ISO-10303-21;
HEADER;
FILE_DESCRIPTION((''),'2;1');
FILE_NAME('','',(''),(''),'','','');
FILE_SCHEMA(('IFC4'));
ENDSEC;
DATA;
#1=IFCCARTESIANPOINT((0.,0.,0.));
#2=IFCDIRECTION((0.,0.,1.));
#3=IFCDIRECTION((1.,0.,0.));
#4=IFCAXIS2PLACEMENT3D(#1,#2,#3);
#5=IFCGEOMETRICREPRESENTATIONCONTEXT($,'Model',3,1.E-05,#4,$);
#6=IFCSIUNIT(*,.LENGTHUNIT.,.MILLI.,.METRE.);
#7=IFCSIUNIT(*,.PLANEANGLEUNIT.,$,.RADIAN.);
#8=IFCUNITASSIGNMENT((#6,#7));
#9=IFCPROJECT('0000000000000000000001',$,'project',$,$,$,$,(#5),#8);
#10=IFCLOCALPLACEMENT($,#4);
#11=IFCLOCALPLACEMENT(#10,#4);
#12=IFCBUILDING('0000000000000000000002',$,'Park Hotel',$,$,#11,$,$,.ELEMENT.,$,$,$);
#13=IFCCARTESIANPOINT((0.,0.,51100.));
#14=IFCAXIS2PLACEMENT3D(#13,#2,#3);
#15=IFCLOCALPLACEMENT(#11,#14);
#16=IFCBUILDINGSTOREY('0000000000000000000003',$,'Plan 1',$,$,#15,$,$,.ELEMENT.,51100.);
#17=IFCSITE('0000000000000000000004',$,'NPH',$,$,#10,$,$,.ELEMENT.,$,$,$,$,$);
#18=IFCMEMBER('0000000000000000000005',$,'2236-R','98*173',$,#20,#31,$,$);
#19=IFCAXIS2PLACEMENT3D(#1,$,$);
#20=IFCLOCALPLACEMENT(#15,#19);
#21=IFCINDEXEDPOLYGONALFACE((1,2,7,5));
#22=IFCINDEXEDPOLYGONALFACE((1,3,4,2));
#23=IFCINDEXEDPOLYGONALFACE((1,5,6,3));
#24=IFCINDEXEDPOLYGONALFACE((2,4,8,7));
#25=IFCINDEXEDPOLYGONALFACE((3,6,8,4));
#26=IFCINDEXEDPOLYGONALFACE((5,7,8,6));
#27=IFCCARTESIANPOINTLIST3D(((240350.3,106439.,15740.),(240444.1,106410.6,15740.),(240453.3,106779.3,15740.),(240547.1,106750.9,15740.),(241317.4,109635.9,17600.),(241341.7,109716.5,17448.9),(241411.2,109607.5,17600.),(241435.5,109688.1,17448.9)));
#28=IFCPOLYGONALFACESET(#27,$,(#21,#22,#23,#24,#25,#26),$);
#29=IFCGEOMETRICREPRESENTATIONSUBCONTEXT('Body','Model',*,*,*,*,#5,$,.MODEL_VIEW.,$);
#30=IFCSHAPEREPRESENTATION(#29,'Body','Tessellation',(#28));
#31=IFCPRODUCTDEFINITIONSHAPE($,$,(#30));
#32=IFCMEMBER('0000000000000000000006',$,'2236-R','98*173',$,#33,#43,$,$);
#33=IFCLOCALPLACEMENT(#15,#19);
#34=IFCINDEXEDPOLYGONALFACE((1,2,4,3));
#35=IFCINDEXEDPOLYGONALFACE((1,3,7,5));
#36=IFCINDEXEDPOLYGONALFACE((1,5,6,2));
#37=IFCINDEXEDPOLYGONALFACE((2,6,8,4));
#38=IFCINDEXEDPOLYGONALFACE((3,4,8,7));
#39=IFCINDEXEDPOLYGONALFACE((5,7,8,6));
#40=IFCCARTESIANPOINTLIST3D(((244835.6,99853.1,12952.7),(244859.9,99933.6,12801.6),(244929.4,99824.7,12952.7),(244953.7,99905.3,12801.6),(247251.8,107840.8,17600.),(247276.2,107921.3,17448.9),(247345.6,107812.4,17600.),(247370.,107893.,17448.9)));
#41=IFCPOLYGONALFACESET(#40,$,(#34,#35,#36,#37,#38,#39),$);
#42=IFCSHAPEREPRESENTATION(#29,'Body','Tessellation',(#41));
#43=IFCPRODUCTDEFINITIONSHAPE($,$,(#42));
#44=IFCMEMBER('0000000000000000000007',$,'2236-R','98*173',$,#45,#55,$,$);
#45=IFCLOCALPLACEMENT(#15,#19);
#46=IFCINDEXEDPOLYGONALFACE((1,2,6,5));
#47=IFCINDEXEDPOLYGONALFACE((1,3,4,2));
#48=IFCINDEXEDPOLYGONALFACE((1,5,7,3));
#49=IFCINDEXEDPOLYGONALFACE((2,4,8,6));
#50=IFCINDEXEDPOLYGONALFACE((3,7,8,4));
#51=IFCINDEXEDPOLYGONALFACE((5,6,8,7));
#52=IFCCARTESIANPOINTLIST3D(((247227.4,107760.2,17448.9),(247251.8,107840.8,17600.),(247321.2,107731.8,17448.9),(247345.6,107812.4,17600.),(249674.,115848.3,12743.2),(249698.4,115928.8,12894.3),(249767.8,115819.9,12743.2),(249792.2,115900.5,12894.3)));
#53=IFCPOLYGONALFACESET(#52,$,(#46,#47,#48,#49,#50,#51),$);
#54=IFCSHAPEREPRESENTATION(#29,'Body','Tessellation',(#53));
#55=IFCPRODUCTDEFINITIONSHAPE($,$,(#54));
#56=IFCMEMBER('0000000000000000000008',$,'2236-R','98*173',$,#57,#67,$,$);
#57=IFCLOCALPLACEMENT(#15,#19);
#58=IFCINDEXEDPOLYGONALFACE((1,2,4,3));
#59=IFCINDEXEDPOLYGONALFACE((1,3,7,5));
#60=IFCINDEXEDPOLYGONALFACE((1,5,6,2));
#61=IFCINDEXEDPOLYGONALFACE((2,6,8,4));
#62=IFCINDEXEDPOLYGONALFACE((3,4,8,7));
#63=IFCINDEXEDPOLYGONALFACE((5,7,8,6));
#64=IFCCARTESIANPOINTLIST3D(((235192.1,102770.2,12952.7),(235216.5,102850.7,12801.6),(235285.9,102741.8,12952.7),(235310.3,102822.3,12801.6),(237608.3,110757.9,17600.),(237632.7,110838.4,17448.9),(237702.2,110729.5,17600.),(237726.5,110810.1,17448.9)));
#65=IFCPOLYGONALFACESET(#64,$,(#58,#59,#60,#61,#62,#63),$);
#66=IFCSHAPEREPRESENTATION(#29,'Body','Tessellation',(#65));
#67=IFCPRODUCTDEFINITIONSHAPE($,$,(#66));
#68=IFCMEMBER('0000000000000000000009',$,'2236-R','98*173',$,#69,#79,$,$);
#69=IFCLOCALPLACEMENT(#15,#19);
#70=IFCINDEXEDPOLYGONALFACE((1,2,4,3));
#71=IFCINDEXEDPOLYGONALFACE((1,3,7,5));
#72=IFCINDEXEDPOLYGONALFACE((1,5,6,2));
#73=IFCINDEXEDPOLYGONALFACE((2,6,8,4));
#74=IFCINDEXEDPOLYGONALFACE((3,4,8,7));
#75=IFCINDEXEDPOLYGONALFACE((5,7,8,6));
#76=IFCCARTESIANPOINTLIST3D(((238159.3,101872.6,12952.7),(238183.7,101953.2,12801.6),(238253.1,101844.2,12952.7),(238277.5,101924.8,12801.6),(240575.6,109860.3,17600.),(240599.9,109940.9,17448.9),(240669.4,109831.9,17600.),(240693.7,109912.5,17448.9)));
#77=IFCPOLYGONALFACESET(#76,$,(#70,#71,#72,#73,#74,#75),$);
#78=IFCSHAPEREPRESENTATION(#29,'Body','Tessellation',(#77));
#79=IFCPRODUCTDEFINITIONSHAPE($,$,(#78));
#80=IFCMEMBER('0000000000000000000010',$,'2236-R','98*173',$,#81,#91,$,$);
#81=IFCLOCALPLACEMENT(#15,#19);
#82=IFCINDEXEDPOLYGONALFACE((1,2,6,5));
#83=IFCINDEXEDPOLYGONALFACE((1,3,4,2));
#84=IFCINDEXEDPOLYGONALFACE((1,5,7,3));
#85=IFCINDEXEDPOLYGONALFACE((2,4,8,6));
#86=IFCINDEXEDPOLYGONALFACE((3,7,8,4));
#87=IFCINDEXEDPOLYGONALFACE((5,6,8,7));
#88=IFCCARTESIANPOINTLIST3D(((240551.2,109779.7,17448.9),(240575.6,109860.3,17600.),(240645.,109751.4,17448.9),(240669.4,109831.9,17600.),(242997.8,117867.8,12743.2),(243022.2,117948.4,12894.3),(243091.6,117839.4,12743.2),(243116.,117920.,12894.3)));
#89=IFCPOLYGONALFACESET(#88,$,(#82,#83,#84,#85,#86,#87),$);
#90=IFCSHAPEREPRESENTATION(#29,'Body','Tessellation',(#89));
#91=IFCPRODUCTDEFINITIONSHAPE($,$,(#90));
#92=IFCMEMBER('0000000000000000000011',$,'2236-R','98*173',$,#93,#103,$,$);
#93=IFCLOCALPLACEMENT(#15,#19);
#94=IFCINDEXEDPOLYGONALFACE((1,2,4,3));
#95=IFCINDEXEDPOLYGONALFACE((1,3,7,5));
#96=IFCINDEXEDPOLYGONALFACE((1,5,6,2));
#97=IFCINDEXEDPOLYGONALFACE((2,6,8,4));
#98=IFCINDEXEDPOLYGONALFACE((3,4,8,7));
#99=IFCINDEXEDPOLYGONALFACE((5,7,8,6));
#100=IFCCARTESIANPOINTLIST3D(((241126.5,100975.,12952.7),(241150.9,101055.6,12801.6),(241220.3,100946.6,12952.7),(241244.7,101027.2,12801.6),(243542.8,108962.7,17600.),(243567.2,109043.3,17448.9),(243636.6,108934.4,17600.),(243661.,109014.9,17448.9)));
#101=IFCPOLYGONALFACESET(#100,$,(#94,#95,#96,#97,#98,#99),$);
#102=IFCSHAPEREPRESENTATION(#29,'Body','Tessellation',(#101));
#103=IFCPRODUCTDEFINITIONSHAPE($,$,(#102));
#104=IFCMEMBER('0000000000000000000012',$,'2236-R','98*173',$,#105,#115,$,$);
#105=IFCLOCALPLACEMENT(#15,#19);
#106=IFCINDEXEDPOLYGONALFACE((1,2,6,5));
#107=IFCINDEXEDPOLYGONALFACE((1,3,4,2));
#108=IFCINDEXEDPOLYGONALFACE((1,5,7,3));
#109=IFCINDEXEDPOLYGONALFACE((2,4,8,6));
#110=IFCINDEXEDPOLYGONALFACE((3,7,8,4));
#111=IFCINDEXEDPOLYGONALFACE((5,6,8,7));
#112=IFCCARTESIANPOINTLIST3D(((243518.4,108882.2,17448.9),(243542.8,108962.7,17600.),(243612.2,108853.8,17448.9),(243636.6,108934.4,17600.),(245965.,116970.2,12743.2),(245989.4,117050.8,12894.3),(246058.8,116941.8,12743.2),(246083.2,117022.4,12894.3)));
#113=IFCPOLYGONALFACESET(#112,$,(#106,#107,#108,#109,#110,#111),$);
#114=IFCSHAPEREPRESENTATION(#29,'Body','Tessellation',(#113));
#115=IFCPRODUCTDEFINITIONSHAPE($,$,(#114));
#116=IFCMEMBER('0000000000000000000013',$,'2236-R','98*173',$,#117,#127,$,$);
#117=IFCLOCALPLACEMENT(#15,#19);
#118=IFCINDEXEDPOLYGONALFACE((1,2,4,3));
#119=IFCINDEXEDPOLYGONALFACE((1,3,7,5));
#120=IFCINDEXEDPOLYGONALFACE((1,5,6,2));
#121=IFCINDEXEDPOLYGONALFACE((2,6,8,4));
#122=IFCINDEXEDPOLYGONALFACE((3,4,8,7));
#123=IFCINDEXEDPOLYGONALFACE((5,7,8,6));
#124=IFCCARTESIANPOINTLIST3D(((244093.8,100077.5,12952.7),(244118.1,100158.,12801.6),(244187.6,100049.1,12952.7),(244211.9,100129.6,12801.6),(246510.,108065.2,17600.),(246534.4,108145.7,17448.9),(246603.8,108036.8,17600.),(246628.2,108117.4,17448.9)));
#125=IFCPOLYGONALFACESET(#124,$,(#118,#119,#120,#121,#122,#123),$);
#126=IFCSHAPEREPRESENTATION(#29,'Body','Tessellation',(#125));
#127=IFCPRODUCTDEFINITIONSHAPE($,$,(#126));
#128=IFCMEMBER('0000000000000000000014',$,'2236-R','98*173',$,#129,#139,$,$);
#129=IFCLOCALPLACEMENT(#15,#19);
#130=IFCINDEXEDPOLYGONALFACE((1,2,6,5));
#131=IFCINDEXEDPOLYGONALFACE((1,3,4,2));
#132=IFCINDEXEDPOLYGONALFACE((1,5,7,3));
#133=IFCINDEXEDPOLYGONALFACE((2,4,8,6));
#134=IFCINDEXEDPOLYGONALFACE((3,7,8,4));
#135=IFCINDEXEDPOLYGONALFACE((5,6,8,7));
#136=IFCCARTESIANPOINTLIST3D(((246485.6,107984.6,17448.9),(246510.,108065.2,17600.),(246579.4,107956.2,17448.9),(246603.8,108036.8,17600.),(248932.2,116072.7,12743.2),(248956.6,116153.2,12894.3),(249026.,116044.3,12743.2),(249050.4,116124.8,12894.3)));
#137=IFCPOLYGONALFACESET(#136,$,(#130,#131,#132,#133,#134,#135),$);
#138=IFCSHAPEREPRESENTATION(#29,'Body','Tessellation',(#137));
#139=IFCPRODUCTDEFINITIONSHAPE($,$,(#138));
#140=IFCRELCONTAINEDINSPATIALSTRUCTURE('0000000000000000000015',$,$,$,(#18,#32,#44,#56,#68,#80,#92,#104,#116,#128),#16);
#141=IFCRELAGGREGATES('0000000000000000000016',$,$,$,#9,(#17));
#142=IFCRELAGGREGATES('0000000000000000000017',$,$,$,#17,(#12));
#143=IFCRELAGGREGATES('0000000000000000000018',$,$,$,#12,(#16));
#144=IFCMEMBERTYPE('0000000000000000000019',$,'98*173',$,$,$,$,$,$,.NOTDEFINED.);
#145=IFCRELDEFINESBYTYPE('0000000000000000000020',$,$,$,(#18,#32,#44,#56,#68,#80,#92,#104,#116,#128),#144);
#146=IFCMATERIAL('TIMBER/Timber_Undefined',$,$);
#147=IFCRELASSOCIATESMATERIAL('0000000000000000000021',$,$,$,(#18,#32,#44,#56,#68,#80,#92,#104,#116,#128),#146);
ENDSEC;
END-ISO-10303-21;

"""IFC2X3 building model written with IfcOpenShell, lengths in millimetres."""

from ifc_helpers import new_model, si_unit, frame, origin_with_axes, origin_2d_with_axis, place, context, subcontext, project, spatial, rectangle, extrude, clip, halfspace, material, type_object, element, save


model = new_model("IFC2X3")

# Units and contexts
model_context = context("Model", 3, precision=1e-05, world=origin_with_axes())
body_context = subcontext(model_context, "Body", "Model", "MODEL_VIEW")
ifc_project = project(units=[si_unit("LENGTHUNIT", "METRE", prefix="MILLI"), si_unit("PLANEANGLEUNIT", "RADIAN")], contexts=[model_context])

# Site, building, storey
site_placement = place(None, origin_with_axes())
site = spatial("IfcSite", under=ifc_project, at=site_placement, Name="NPH", CompositionType="ELEMENT")
building_placement = place(site_placement, origin_with_axes())
building = spatial("IfcBuilding", under=site, at=building_placement, Name="Park Hotel", CompositionType="ELEMENT")
storey_placement = place(building_placement, frame((0.0, 0.0, 51100.0), z_axis=(0.0, 0.0, 1.0), x_axis=(1.0, 0.0, 0.0)))
storey = spatial("IfcBuildingStorey", under=building, at=storey_placement, Name="Plan 1", CompositionType="ELEMENT", Elevation=51100.0)

# Members
ifc_material = material(Name="TIMBER/Timber_Undefined")
member_type = type_object("IfcMemberType", Name="98*173", PredefinedType="NOTDEFINED")
member_1_placement = place(storey_placement, frame((241376.5, 109662.0, 17524.4), z_axis=(-0.957167, 0.289538, 0.0), x_axis=(-0.252959, -0.836241, -0.486531)))
element("IfcMember", 1, at=member_1_placement, inside=storey, type_object=member_type, material=ifc_material, Name="2236-R", Description="98*173", context=body_context, shape_type="Clipping", body=[
    clip(extrude(rectangle(XDim=173.0, YDim=98.0, at=origin_2d_with_axis()), frame((9551.9, 0.0, 0.0), z_axis=(-1.0, 0.0, 0.0), x_axis=(0.0, -1.0, 0.0)), (0.0, 0.0, 1.0), 9551.9), halfspace(frame((4639.3, 541.1, -40.5), z_axis=(0.486531, -0.873663, 0.0), x_axis=(0.0, 0.0, -1.0)), False)),
])
member_2_placement = place(storey_placement, frame((247310.9, 107866.9, 17524.4), z_axis=(-0.957167, 0.289538, 0.0), x_axis=(-0.252959, -0.836241, -0.486531)))
element("IfcMember", 2, at=member_2_placement, inside=storey, type_object=member_type, material=ifc_material, Name="2236-R", Description="98*173", context=body_context, shape_type="SweptSolid", body=[
    extrude(rectangle(XDim=173.0, YDim=98.0, at=origin_2d_with_axis()), frame((9551.9, 0.0, 0.0), z_axis=(-1.0, 0.0, 0.0), x_axis=(0.0, -1.0, 0.0)), (0.0, 0.0, 1.0), 9551.9),
])
member_3_placement = place(storey_placement, frame((247286.5, 107786.3, 17524.4), z_axis=(-0.957167, 0.289538, 0.0), x_axis=(0.252959, 0.836242, -0.48653)))
element("IfcMember", 3, at=member_3_placement, inside=storey, type_object=member_type, material=ifc_material, Name="2236-R", Description="98*173", context=body_context, shape_type="SweptSolid", body=[
    extrude(rectangle(XDim=173.0, YDim=98.0, at=origin_2d_with_axis()), frame((9671.9, 0.0, 0.0), z_axis=(-1.0, 0.0, 0.0), x_axis=(0.0, -1.0, 0.0)), (0.0, 0.0, 1.0), 9671.9),
])
for number, where, z_axis, x_axis, name in (
    (4, (237667.4, 110784.0, 17524.4), (-0.957167, 0.289538, 0.0), (-0.252959, -0.836241, -0.486531), "2236-R"),
    (5, (240634.7, 109886.4, 17524.4), (-0.957167, 0.289538, 0.0), (-0.252959, -0.836241, -0.486531), "2236-R"),
):
    element("IfcMember", number, at=place(storey_placement, frame(where, z_axis=z_axis, x_axis=x_axis)), inside=storey, type_object=member_type, material=ifc_material, Name=name, Description="98*173", context=body_context, shape_type="SweptSolid", body=[
        extrude(rectangle(XDim=173.0, YDim=98.0, at=origin_2d_with_axis()), frame((9551.9, 0.0, 0.0), z_axis=(-1.0, 0.0, 0.0), x_axis=(0.0, -1.0, 0.0)), (0.0, 0.0, 1.0), 9551.9),
    ])
member_4_placement = place(storey_placement, frame((240610.3, 109805.8, 17524.4), z_axis=(-0.957167, 0.289538, 0.0), x_axis=(0.252959, 0.836242, -0.48653)))
element("IfcMember", 6, at=member_4_placement, inside=storey, type_object=member_type, material=ifc_material, Name="2236-R", Description="98*173", context=body_context, shape_type="SweptSolid", body=[
    extrude(rectangle(XDim=173.0, YDim=98.0, at=origin_2d_with_axis()), frame((9671.9, 0.0, 0.0), z_axis=(-1.0, 0.0, 0.0), x_axis=(0.0, -1.0, 0.0)), (0.0, 0.0, 1.0), 9671.9),
])
member_5_placement = place(storey_placement, frame((243601.9, 108988.8, 17524.4), z_axis=(-0.957167, 0.289538, 0.0), x_axis=(-0.252959, -0.836241, -0.486531)))
element("IfcMember", 7, at=member_5_placement, inside=storey, type_object=member_type, material=ifc_material, Name="2236-R", Description="98*173", context=body_context, shape_type="SweptSolid", body=[
    extrude(rectangle(XDim=173.0, YDim=98.0, at=origin_2d_with_axis()), frame((9551.9, 0.0, 0.0), z_axis=(-1.0, 0.0, 0.0), x_axis=(0.0, -1.0, 0.0)), (0.0, 0.0, 1.0), 9551.9),
])
member_6_placement = place(storey_placement, frame((243577.5, 108908.3, 17524.4), z_axis=(-0.957167, 0.289538, 0.0), x_axis=(0.252959, 0.836242, -0.48653)))
element("IfcMember", 8, at=member_6_placement, inside=storey, type_object=member_type, material=ifc_material, Name="2236-R", Description="98*173", context=body_context, shape_type="SweptSolid", body=[
    extrude(rectangle(XDim=173.0, YDim=98.0, at=origin_2d_with_axis()), frame((9671.9, 0.0, 0.0), z_axis=(-1.0, 0.0, 0.0), x_axis=(0.0, -1.0, 0.0)), (0.0, 0.0, 1.0), 9671.9),
])
member_7_placement = place(storey_placement, frame((246569.1, 108091.3, 17524.4), z_axis=(-0.957167, 0.289538, 0.0), x_axis=(-0.252959, -0.836241, -0.486531)))
element("IfcMember", 9, at=member_7_placement, inside=storey, type_object=member_type, material=ifc_material, Name="2236-R", Description="98*173", context=body_context, shape_type="SweptSolid", body=[
    extrude(rectangle(XDim=173.0, YDim=98.0, at=origin_2d_with_axis()), frame((9551.9, 0.0, 0.0), z_axis=(-1.0, 0.0, 0.0), x_axis=(0.0, -1.0, 0.0)), (0.0, 0.0, 1.0), 9551.9),
])
member_8_placement = place(storey_placement, frame((246544.7, 108010.7, 17524.4), z_axis=(-0.957167, 0.289538, 0.0), x_axis=(0.252959, 0.836242, -0.48653)))
element("IfcMember", 10, at=member_8_placement, inside=storey, type_object=member_type, material=ifc_material, Name="2236-R", Description="98*173", context=body_context, shape_type="SweptSolid", body=[
    extrude(rectangle(XDim=173.0, YDim=98.0, at=origin_2d_with_axis()), frame((9671.9, 0.0, 0.0), z_axis=(-1.0, 0.0, 0.0), x_axis=(0.0, -1.0, 0.0)), (0.0, 0.0, 1.0), 9671.9),
])

save(model, "model.ifc")
